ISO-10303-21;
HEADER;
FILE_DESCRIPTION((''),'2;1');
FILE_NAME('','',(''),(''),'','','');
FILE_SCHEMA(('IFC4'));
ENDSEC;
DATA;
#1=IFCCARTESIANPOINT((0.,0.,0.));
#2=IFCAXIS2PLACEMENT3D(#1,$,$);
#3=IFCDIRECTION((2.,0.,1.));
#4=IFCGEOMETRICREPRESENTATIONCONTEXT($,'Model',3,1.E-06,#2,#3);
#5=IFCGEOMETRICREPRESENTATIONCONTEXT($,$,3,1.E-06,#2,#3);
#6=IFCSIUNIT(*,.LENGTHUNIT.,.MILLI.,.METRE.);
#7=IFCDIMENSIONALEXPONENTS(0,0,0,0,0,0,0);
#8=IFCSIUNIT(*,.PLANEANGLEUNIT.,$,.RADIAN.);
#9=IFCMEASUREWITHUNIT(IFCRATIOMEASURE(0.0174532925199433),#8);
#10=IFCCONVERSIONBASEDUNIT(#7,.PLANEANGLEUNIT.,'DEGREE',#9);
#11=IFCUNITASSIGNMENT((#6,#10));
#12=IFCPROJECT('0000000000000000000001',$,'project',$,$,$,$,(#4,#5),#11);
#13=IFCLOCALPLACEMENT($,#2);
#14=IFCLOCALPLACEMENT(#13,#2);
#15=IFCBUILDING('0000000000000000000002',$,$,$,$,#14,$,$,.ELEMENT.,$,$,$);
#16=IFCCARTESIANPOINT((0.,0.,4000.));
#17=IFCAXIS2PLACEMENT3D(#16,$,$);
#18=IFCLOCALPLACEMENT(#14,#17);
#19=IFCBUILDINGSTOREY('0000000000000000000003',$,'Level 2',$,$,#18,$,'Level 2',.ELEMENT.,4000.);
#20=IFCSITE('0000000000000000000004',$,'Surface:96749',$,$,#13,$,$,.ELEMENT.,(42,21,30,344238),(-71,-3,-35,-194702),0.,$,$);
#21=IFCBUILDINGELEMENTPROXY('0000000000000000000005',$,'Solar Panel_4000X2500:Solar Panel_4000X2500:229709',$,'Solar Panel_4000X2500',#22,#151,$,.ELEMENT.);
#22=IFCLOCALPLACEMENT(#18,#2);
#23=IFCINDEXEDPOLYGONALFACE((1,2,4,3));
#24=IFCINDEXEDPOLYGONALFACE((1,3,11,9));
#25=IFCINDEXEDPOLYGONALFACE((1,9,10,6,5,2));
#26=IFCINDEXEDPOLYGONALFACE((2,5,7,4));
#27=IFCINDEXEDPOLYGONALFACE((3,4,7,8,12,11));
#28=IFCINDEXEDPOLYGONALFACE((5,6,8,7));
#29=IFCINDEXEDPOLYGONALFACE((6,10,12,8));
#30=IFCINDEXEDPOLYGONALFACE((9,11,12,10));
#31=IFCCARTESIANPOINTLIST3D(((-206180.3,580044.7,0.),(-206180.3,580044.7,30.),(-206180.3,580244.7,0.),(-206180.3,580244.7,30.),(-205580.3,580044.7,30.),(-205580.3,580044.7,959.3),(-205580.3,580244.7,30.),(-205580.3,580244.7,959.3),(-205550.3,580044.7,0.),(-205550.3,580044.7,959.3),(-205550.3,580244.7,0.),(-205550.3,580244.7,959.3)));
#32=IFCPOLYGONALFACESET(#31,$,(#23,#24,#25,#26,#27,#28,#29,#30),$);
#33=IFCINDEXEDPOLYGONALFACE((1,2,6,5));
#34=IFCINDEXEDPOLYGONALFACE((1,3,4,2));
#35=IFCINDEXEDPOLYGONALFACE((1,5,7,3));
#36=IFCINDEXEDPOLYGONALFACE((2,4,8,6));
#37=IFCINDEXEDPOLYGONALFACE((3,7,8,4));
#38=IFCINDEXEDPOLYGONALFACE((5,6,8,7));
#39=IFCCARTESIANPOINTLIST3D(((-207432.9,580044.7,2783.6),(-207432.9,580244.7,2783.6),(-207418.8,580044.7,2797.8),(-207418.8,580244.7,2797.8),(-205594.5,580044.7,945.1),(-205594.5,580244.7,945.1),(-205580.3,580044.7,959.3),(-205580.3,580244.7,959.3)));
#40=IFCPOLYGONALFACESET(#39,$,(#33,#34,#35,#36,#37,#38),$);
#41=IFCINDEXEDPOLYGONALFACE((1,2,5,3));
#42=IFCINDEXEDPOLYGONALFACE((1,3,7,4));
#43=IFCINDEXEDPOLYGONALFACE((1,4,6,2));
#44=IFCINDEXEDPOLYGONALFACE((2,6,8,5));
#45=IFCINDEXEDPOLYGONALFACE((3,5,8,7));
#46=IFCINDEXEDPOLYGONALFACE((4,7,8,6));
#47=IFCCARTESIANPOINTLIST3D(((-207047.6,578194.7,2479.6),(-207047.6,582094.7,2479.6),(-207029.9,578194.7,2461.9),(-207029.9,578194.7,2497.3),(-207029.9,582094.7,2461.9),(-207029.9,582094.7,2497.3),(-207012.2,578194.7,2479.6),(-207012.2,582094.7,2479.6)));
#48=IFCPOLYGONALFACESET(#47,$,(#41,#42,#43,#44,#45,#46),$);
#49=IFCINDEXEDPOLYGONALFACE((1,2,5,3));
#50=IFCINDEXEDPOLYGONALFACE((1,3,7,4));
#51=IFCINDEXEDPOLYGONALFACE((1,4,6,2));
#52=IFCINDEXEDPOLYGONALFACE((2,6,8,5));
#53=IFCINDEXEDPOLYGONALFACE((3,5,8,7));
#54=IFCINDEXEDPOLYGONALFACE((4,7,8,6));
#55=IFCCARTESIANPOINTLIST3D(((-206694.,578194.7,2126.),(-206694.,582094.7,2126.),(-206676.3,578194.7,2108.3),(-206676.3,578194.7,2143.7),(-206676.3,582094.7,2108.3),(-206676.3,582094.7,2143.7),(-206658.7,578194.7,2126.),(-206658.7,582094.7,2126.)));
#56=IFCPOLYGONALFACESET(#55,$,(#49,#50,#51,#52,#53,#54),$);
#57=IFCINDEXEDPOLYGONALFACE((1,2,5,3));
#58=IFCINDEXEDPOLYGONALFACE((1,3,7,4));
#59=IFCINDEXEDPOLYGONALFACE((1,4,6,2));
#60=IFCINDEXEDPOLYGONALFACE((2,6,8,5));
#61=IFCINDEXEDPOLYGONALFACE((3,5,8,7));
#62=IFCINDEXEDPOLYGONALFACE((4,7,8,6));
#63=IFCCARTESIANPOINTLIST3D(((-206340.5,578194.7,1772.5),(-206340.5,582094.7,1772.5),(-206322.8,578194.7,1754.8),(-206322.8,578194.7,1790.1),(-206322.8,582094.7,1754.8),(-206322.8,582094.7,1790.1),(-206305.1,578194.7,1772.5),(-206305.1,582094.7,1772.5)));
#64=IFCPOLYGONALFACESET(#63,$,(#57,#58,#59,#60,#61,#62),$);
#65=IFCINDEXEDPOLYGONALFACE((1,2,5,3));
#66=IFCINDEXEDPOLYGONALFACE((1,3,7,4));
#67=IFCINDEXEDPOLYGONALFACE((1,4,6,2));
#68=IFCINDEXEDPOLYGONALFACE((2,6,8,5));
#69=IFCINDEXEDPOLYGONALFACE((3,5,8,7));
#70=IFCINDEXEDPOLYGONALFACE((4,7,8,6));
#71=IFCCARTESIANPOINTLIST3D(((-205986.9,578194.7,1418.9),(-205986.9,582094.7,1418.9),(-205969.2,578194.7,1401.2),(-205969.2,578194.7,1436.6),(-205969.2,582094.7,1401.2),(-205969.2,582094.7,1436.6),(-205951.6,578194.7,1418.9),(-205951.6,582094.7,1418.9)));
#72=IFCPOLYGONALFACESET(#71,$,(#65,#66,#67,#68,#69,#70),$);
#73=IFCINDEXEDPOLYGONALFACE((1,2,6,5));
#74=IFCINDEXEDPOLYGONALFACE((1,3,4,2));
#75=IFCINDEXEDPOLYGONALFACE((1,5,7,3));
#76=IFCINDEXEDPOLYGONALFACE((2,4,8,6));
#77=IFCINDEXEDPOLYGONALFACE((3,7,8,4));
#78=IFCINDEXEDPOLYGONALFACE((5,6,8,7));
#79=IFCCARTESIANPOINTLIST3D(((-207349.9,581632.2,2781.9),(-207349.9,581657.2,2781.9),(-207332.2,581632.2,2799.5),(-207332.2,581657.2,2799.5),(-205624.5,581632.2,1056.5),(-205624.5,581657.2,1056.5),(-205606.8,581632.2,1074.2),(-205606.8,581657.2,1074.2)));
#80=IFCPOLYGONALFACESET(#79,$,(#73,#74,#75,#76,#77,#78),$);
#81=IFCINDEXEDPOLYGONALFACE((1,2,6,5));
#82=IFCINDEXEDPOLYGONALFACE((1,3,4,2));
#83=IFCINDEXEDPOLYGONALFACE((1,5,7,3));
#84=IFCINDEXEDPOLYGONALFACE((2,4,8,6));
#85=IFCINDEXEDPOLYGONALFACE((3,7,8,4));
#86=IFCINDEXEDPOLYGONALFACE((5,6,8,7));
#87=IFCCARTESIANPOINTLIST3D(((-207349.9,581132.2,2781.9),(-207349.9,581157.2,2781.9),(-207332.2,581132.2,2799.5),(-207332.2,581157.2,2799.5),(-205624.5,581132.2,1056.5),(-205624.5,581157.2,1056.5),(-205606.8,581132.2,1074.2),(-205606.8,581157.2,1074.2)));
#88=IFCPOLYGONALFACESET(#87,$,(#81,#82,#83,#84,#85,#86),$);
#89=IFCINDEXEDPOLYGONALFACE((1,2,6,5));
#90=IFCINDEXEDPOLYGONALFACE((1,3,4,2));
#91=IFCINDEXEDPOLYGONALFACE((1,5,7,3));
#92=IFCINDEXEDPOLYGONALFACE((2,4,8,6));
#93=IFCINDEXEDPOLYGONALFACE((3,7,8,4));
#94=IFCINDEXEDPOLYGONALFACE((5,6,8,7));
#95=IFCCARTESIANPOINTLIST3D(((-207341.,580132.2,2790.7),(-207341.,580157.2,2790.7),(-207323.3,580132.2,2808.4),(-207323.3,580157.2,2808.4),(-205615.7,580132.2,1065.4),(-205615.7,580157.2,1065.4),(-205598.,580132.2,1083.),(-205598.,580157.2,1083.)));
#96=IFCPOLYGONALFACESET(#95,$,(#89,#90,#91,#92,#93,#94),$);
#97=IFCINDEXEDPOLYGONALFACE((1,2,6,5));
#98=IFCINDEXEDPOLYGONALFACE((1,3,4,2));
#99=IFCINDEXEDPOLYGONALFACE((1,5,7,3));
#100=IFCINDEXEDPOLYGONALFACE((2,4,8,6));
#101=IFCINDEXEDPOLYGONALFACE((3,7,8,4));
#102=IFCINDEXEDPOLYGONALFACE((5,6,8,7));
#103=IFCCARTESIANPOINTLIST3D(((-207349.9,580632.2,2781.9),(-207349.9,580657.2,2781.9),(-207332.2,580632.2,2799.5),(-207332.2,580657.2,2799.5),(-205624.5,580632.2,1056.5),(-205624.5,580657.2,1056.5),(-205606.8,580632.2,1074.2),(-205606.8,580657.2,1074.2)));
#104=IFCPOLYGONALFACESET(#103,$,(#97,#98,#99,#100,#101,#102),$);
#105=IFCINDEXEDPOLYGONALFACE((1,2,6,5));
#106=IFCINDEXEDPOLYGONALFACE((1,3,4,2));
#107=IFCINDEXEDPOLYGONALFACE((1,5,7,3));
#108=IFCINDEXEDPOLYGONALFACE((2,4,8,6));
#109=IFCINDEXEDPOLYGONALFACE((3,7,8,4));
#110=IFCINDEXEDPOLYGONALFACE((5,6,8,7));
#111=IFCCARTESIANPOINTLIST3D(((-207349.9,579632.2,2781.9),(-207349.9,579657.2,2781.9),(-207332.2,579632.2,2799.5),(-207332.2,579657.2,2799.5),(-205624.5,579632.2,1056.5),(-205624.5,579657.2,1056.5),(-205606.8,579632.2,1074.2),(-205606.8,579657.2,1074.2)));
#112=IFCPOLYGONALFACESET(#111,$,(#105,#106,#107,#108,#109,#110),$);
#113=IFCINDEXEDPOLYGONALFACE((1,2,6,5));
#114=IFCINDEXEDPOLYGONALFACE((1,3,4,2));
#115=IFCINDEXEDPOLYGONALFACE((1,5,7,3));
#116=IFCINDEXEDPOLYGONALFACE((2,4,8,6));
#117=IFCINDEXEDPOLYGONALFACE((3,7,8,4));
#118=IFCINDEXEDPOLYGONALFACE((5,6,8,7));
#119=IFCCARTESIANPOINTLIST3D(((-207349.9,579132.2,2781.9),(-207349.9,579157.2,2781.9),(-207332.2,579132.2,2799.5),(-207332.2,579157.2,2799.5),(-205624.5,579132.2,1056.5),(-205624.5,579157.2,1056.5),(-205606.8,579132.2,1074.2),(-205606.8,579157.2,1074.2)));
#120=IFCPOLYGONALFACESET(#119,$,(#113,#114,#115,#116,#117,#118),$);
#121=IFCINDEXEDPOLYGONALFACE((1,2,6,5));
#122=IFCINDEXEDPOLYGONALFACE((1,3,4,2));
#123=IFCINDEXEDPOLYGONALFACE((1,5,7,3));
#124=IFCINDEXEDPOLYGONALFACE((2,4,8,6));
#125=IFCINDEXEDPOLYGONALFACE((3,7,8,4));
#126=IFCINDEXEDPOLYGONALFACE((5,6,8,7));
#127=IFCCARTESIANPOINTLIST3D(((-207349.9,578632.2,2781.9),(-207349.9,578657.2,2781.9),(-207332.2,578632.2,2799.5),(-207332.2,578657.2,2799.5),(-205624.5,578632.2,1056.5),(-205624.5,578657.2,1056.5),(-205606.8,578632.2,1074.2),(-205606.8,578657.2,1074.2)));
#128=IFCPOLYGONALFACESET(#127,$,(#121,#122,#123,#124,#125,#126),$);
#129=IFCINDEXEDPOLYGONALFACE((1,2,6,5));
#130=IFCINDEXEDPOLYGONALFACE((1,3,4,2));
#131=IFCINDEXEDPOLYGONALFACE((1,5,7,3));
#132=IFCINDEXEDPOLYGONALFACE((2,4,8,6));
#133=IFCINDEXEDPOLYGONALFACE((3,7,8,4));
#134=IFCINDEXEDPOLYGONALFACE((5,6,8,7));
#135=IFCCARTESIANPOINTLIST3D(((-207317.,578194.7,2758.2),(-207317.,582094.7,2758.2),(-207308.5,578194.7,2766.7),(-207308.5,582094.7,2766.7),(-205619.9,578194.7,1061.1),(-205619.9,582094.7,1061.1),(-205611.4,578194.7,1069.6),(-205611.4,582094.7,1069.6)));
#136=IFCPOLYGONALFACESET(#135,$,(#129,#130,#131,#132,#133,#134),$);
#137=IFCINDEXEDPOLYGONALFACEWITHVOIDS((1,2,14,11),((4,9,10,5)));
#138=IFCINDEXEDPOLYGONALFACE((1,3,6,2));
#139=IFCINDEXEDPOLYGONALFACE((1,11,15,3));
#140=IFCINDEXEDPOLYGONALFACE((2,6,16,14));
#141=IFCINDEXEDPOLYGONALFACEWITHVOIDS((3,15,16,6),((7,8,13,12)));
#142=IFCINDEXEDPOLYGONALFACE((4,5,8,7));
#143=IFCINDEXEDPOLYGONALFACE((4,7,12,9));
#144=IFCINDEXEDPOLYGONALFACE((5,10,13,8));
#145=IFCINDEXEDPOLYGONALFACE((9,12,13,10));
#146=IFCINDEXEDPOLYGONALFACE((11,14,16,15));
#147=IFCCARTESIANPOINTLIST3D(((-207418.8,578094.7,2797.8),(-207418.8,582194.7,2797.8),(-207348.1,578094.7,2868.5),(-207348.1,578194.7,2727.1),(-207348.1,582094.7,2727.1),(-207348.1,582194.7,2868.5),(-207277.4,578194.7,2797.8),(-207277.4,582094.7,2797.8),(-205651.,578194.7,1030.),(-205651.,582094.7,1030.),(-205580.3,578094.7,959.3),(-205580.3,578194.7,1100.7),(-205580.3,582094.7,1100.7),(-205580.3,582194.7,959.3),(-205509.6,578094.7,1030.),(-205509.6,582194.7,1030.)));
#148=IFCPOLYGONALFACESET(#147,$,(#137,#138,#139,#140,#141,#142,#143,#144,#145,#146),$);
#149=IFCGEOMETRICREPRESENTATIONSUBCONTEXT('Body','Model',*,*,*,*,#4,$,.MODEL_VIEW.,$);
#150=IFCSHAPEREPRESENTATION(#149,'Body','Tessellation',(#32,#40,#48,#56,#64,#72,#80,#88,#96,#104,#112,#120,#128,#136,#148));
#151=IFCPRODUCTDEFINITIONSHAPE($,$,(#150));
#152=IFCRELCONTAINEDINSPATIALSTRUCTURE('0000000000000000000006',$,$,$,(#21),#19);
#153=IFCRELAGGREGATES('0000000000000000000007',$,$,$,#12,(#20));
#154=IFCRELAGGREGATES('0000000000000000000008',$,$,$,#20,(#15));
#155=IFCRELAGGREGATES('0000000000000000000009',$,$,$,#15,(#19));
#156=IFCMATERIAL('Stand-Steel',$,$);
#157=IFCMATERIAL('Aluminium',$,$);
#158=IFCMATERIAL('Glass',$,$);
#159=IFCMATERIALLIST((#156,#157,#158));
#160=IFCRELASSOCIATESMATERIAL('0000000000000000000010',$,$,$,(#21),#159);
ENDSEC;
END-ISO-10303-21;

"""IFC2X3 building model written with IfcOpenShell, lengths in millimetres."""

from ifc_helpers import new_model, entity, si_unit, converted_unit, direction, frame, frame_2d, origin, origin_2d_with_axis, place, context, subcontext, project, spatial, polyline, rectangle, outline, extrude, source, transform, mapped, material, material_list, element, save


model = new_model("IFC2X3")

# Units and contexts
model_context = context("Model", 3, precision=1e-06, world=origin(), true_north=direction((2.0, 0.0, 1.0)))
context_of_model = context(None, 3, precision=1e-06, world=origin(), true_north=direction((2.0, 0.0, 1.0)))
body_context = subcontext(model_context, "Body", "Model", "MODEL_VIEW")
ifc_project = project(units=[si_unit("LENGTHUNIT", "METRE", prefix="MILLI"), converted_unit("PLANEANGLEUNIT", "DEGREE", entity("IfcRatioMeasure", 0.0174532925199433), si_unit("PLANEANGLEUNIT", "RADIAN"), dimensions=[0, 0, 0, 0, 0, 0, 0])], contexts=[model_context, context_of_model])

# Site, building, storey
site_placement = place(None, origin())
site = spatial("IfcSite", under=ifc_project, at=site_placement, Name="Surface:96749", CompositionType="ELEMENT", RefLatitude=(42, 21, 30, 344238), RefLongitude=(-71, -3, -35, -194702), RefElevation=0.0)
building_placement = place(site_placement, origin())
building = spatial("IfcBuilding", under=site, at=building_placement, CompositionType="ELEMENT")
storey_placement = place(building_placement, frame((0.0, 0.0, 4000.0)))
storey = spatial("IfcBuildingStorey", under=building, at=storey_placement, Name="Level 2", LongName="Level 2", CompositionType="ELEMENT", Elevation=4000.0)

# Building element proxy
ifc_material_1 = material(Name="Stand-Steel")
ifc_material_2 = material(Name="Aluminium")
ifc_material_3 = material(Name="Glass")
shared_shape = source(origin(), body_context, "Body", "SweptSolid", [
    extrude(outline(polyline([(-629.5, -220.0), (329.8, -220.0), (329.8, 410.0), (299.8, 410.0), (299.8, -190.0), (-629.5, -190.0), (-629.5, -220.0)])), frame((-190.0, -100.0, 299.8), z_axis=(0.0, 1.0, 0.0), x_axis=(0.0, 0.0, -1.0)), (0.0, 0.0, 1.0), 200.0),
    extrude(rectangle(XDim=20.0, YDim=200.0, at=frame_2d((0.0, 0.0), x_axis=(0.0, 1.0))), frame((-7.1, 0.0, 922.2), z_axis=(-0.707107, 0.0, 0.707107), x_axis=(0.0, 1.0, 0.0)), (0.0, 0.0, 1.0), 2600.0),
    extrude(rectangle(XDim=25.0, YDim=25.0, at=frame_2d((0.0, 0.0), x_axis=(1.0, 0.0))), frame((-1449.6, -1950.0, 2449.6), z_axis=(0.0, 1.0, 0.0), x_axis=(-0.707107, 0.0, -0.707107)), (0.0, 0.0, 1.0), 3900.0),
    extrude(rectangle(XDim=25.0, YDim=25.0, at=origin_2d_with_axis()), frame((-1096.0, -1950.0, 2096.0), z_axis=(0.0, 1.0, 0.0), x_axis=(-0.707107, 0.0, -0.707107)), (0.0, 0.0, 1.0), 3900.0),
    extrude(rectangle(XDim=25.0, YDim=25.0, at=origin_2d_with_axis()), frame((-742.5, -1950.0, 1742.5), z_axis=(0.0, 1.0, 0.0), x_axis=(-0.707107, 0.0, -0.707107)), (0.0, 0.0, 1.0), 3900.0),
    extrude(rectangle(XDim=25.0, YDim=25.0, at=frame_2d((0.0, 0.0), x_axis=(1.0, 0.0))), frame((-388.9, -1950.0, 1388.9), z_axis=(0.0, 1.0, 0.0), x_axis=(-0.707107, 0.0, -0.707107)), (0.0, 0.0, 1.0), 3900.0),
    extrude(rectangle(XDim=25.0, YDim=25.0, at=frame_2d((0.0, 0.0), x_axis=(0.0, 1.0))), frame((-35.4, 1500.0, 1035.4), z_axis=(-0.707107, 0.0, 0.707107), x_axis=(0.0, 1.0, 0.0)), (0.0, 0.0, 1.0), 2440.0),
    extrude(rectangle(XDim=25.0, YDim=25.0, at=frame_2d((0.0, 0.0), x_axis=(0.0, 1.0))), frame((-35.4, 1000.0, 1035.4), z_axis=(-0.707107, 0.0, 0.707107), x_axis=(0.0, 1.0, 0.0)), (0.0, 0.0, 1.0), 2440.0),
    extrude(rectangle(XDim=25.0, YDim=25.0, at=frame_2d((0.0, 0.0), x_axis=(0.0, 1.0))), frame((-26.5, 0.0, 1044.2), z_axis=(-0.707107, 0.0, 0.707107), x_axis=(0.0, -1.0, 0.0)), (0.0, 0.0, 1.0), 2440.0),
    extrude(rectangle(XDim=25.0, YDim=25.0, at=frame_2d((0.0, 0.0), x_axis=(0.0, 1.0))), frame((-35.4, 500.0, 1035.4), z_axis=(-0.707107, 0.0, 0.707107), x_axis=(0.0, 1.0, 0.0)), (0.0, 0.0, 1.0), 2440.0),
    extrude(rectangle(XDim=25.0, YDim=25.0, at=frame_2d((0.0, 0.0), x_axis=(0.0, 1.0))), frame((-35.4, -500.0, 1035.4), z_axis=(-0.707107, 0.0, 0.707107), x_axis=(0.0, 1.0, 0.0)), (0.0, 0.0, 1.0), 2440.0),
    extrude(rectangle(XDim=25.0, YDim=25.0, at=frame_2d((0.0, 0.0), x_axis=(0.0, 1.0))), frame((-35.4, -1000.0, 1035.4), z_axis=(-0.707107, 0.0, 0.707107), x_axis=(0.0, 1.0, 0.0)), (0.0, 0.0, 1.0), 2440.0),
    extrude(rectangle(XDim=25.0, YDim=25.0, at=frame_2d((0.0, 0.0), x_axis=(0.0, 1.0))), frame((-35.4, -1500.0, 1035.4), z_axis=(-0.707107, 0.0, 0.707107), x_axis=(0.0, 1.0, 0.0)), (0.0, 0.0, 1.0), 2440.0),
    extrude(rectangle(XDim=2400.0, YDim=12.0, at=frame_2d((0.0, 0.0), x_axis=(1.0, 0.0))), frame((-883.9, -1950.0, 1883.9), z_axis=(0.0, 1.0, 0.0), x_axis=(0.707107, 0.0, -0.707107)), (0.0, 0.0, 1.0), 3900.0),
    extrude(outline(polyline([(-2050.0, -1300.0), (2050.0, -1300.0), (2050.0, 1300.0), (-2050.0, 1300.0), (-2050.0, -1300.0)]), holes=[polyline([(1950.0, -1200.0), (-1950.0, -1200.0), (-1950.0, 1200.0), (1950.0, 1200.0), (1950.0, -1200.0)])]), frame((-919.2, 0.0, 1848.5), z_axis=(0.707107, 0.0, 0.707107), x_axis=(0.0, 1.0, 0.0)), (0.0, 0.0, 1.0), 100.0),
])
ifc_material_list_1 = material_list([ifc_material_1, ifc_material_2, ifc_material_3])
proxy_1_placement = place(storey_placement, frame((-205580.3, 580144.7, 30.0)))
element("IfcBuildingElementProxy", 1, at=proxy_1_placement, inside=storey, material=ifc_material_list_1, Name="Solar Panel_4000X2500:Solar Panel_4000X2500:229709", ObjectType="Solar Panel_4000X2500", CompositionType="ELEMENT", context=body_context, shape_type="MappedRepresentation", body=[
    mapped(shared_shape, transform((0.0, 0.0, 0.0), scale=1.0)),
])

save(model, "model.ifc")
